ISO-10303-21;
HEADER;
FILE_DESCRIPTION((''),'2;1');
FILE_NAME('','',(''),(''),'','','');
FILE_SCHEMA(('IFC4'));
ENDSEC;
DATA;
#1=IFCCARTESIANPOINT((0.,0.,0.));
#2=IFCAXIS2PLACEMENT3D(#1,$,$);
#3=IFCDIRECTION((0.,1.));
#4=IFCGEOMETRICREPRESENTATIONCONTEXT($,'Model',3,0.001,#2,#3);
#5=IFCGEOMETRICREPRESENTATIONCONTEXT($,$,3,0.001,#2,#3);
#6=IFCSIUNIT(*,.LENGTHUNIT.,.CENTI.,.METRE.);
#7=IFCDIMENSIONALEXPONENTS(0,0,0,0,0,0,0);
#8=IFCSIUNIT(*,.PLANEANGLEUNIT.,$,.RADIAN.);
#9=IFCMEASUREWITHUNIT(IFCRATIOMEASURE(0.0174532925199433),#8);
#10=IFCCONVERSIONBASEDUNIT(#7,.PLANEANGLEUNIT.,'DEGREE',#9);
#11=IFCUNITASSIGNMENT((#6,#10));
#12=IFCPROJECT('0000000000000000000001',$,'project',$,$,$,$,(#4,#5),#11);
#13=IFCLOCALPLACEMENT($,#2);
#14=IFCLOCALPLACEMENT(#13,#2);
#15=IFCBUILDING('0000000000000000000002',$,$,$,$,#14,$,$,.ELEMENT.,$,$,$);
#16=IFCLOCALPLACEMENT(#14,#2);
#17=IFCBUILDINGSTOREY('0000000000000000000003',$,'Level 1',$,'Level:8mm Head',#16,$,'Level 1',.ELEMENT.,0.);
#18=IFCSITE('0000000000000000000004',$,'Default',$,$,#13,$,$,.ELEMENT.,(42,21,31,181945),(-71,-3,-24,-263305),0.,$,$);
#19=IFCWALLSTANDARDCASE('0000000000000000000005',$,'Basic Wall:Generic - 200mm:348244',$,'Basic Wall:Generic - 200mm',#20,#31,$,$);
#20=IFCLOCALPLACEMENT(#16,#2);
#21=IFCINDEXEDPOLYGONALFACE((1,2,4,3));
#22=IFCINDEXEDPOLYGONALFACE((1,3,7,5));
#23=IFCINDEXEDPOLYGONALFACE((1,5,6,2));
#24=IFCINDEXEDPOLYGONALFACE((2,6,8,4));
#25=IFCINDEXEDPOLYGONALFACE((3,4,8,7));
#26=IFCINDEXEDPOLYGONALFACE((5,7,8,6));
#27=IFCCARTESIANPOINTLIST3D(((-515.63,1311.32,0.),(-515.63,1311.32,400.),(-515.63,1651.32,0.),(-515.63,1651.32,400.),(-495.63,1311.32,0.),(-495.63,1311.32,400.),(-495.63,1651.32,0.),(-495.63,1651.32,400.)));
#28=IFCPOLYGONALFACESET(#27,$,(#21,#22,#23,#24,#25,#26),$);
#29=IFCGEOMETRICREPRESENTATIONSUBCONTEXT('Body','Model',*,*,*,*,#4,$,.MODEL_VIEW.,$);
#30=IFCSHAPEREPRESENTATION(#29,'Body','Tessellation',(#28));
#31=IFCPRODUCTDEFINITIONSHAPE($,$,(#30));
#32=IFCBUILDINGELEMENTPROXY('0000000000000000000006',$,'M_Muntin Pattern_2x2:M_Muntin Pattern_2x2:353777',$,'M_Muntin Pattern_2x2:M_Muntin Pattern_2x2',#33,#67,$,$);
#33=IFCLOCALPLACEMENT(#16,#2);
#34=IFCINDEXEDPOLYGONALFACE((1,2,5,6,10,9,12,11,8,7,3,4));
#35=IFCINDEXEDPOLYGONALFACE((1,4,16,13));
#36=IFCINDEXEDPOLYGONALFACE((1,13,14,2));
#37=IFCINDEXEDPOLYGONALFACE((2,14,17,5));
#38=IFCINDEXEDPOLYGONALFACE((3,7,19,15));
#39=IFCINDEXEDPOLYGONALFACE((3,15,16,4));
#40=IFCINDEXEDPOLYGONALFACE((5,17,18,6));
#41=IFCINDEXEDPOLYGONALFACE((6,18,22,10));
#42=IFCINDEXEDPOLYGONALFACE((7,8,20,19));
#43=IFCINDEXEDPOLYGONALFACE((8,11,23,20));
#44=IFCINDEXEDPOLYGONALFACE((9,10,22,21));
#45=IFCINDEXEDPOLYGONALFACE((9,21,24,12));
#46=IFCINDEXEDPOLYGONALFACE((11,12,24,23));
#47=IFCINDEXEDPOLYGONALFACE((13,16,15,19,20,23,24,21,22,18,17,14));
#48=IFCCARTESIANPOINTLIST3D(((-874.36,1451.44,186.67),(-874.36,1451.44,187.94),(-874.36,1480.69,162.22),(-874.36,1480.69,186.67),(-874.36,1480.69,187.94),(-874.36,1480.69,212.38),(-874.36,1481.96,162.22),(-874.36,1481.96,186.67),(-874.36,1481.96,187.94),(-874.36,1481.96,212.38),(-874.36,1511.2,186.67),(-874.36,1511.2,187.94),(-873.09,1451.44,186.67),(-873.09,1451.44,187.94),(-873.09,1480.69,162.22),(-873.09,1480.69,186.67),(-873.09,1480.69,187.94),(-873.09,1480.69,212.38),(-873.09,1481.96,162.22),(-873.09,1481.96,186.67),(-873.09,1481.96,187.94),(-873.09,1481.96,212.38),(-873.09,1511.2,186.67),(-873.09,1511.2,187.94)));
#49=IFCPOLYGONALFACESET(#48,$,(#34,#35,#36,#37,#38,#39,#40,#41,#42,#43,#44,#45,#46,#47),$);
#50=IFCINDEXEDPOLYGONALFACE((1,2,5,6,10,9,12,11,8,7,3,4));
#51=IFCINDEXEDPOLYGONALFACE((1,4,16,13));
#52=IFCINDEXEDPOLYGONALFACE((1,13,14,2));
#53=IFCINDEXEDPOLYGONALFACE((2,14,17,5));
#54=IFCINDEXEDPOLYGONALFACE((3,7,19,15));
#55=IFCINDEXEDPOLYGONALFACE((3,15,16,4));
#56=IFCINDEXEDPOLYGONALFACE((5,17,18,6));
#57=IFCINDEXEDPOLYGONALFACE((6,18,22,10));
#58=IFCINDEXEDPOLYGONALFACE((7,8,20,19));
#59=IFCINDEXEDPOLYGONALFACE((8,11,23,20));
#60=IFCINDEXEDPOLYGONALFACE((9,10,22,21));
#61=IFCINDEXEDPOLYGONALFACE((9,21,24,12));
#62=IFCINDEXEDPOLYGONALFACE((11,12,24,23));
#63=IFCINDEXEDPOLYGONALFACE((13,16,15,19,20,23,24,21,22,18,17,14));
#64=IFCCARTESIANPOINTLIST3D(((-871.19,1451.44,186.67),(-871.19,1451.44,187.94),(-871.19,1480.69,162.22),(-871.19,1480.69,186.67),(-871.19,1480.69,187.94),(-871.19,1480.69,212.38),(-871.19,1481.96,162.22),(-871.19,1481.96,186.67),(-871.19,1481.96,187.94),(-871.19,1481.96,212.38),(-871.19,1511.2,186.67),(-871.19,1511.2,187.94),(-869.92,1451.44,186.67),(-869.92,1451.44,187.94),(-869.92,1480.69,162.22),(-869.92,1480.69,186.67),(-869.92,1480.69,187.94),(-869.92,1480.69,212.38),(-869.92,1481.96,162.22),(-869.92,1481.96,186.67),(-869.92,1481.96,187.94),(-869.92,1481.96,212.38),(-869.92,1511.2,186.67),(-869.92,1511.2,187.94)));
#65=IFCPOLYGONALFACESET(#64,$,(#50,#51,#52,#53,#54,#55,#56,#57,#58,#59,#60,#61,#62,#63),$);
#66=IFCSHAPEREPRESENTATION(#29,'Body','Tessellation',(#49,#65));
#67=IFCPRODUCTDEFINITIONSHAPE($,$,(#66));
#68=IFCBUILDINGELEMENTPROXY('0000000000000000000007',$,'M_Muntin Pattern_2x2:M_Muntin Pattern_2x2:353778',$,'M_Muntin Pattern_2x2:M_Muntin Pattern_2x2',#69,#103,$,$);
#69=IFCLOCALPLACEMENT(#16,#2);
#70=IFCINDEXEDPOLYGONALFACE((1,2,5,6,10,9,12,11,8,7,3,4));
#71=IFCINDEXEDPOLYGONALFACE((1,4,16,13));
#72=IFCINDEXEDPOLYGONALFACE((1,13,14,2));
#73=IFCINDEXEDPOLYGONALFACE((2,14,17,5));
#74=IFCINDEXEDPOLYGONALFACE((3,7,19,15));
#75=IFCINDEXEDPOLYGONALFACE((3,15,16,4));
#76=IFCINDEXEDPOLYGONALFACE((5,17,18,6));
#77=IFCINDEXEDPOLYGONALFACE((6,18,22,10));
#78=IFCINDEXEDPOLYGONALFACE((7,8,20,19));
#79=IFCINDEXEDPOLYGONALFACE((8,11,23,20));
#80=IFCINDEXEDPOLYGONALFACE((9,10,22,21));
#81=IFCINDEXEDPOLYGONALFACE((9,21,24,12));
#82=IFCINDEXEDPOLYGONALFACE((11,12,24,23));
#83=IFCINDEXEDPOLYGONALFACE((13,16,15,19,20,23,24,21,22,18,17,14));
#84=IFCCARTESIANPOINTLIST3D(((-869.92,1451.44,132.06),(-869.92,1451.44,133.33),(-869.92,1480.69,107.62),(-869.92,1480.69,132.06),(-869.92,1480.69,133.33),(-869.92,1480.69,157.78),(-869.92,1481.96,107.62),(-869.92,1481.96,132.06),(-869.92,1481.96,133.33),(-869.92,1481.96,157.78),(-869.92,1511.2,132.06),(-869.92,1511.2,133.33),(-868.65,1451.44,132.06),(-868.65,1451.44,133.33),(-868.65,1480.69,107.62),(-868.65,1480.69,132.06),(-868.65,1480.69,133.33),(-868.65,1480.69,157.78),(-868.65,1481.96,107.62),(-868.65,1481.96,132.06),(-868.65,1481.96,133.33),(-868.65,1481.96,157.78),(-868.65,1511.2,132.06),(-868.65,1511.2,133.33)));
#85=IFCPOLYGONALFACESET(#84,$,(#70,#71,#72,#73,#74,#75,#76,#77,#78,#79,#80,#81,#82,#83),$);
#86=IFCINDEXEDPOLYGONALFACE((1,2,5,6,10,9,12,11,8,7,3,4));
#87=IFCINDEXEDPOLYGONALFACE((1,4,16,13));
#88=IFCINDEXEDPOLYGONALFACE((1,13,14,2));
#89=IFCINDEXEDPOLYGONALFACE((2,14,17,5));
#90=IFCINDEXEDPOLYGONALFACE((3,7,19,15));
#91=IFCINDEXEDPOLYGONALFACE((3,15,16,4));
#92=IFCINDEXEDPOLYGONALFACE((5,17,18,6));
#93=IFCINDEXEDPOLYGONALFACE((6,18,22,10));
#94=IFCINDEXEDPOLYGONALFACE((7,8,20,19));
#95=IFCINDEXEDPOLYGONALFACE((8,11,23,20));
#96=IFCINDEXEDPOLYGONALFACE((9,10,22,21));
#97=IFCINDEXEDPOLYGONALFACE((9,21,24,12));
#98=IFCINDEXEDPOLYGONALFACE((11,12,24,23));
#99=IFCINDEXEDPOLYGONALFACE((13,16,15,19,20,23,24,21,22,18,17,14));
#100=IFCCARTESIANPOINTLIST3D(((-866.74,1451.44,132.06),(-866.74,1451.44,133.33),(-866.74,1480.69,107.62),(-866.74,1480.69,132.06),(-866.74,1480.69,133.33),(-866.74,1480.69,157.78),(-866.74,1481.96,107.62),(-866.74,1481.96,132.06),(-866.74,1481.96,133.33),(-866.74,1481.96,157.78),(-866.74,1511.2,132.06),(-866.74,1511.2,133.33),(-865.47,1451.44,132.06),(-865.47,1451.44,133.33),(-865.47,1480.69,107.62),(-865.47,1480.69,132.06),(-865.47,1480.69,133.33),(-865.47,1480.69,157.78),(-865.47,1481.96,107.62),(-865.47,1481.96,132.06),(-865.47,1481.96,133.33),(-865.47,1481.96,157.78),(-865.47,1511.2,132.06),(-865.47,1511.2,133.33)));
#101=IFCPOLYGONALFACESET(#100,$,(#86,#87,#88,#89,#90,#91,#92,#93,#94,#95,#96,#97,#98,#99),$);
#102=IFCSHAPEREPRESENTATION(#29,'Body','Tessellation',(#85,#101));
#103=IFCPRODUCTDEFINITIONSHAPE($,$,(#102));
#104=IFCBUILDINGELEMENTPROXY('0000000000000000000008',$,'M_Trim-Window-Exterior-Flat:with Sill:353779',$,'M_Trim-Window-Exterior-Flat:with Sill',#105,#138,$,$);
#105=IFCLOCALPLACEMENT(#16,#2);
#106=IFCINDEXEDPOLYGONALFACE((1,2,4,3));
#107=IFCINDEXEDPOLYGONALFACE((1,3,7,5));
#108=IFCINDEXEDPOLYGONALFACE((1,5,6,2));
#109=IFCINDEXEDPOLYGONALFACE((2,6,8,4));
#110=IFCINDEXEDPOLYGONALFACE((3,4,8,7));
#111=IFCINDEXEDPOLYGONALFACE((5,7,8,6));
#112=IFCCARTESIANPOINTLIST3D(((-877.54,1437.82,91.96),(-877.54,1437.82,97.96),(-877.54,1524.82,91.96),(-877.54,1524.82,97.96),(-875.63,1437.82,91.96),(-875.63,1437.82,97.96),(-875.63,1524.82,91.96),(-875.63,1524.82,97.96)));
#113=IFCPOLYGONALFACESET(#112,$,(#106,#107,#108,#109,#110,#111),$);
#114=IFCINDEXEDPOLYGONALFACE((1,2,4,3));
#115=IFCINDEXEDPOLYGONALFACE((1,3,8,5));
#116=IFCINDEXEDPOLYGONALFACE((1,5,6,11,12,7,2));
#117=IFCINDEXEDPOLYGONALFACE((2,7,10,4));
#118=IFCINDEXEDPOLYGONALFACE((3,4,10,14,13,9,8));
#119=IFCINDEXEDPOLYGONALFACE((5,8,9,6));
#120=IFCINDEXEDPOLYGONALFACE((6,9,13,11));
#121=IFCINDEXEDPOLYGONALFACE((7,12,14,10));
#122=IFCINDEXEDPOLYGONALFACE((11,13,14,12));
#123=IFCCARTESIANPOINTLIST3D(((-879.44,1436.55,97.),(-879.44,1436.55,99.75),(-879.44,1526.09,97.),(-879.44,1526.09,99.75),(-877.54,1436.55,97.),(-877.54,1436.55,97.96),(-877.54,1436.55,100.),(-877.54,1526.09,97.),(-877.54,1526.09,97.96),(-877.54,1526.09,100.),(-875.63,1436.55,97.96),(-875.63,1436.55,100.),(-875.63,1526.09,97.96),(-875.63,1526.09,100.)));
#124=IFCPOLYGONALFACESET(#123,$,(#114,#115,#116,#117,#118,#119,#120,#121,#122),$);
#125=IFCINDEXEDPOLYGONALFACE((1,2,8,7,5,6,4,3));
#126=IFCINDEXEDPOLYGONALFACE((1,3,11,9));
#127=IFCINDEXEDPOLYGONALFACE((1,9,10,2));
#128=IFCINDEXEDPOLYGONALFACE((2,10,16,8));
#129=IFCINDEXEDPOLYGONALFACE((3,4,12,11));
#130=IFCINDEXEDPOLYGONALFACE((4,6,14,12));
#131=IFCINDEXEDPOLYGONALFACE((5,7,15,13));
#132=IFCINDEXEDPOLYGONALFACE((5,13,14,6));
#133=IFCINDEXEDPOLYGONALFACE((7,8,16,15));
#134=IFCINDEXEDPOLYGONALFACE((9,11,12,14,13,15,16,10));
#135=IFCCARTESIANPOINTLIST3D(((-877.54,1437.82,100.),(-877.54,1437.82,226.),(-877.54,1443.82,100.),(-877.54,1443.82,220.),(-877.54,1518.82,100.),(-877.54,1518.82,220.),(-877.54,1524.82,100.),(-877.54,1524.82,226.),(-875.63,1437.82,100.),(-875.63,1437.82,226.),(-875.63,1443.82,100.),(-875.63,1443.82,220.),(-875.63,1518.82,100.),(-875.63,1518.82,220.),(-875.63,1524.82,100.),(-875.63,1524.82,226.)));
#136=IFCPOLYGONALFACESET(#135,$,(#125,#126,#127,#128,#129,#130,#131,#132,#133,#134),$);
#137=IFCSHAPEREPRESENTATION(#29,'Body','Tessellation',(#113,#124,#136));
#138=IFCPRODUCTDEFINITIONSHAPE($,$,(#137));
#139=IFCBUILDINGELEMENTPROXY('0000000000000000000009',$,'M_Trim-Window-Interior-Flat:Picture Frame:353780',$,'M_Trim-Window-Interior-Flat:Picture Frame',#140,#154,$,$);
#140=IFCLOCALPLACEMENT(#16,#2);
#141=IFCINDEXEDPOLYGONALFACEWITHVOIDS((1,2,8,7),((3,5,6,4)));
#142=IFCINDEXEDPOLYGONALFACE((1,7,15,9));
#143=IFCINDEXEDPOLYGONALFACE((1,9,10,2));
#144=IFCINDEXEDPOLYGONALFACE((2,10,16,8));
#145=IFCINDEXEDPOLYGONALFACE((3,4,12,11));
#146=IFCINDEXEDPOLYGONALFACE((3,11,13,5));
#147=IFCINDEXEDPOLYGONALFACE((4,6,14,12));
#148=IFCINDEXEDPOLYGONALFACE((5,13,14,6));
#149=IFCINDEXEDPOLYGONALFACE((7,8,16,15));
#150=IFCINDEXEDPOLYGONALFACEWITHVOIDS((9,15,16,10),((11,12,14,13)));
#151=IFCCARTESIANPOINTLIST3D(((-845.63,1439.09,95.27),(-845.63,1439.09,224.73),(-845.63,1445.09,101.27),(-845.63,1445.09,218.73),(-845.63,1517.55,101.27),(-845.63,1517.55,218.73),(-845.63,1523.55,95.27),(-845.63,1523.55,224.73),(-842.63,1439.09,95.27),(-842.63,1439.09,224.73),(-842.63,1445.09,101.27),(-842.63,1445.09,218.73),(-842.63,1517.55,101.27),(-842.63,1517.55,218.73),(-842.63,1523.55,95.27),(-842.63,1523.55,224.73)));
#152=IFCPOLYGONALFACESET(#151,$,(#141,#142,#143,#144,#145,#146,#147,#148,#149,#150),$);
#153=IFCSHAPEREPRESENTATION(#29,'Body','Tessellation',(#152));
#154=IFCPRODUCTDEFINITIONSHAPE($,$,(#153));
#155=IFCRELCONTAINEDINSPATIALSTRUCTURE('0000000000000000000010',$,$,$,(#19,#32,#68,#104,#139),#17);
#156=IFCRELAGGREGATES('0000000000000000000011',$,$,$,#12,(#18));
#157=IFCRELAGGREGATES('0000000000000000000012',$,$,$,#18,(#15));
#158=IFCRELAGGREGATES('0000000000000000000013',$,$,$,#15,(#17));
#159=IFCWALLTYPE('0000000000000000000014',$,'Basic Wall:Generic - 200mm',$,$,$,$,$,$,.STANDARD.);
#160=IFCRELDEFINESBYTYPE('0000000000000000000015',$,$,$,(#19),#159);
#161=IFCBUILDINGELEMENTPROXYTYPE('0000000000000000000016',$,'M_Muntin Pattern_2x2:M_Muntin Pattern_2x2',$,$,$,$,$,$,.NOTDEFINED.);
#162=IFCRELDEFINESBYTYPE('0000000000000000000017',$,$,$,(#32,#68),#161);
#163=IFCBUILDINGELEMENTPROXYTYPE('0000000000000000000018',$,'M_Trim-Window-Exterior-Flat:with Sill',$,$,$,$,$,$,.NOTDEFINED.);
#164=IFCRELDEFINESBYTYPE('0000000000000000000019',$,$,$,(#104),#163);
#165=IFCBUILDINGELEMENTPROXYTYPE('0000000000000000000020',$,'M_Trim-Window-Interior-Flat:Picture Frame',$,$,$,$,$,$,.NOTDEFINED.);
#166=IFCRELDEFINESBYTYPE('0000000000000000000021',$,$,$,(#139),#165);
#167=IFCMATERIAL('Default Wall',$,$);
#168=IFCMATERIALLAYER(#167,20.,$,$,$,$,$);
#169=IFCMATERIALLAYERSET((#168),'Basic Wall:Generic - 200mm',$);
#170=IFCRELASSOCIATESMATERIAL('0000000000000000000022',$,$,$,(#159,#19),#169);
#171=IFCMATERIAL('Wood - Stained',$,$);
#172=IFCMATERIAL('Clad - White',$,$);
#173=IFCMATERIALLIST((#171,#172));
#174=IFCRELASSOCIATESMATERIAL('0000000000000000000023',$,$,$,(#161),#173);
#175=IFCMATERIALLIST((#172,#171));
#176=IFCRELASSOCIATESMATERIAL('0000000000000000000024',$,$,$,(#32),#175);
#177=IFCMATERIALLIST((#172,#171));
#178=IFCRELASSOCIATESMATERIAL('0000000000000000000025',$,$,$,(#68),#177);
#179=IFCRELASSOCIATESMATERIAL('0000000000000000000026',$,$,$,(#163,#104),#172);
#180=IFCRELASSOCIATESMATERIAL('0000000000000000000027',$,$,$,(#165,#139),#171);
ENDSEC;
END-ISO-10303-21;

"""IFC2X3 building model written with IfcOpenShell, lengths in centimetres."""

from ifc_helpers import new_model, entity, si_unit, converted_unit, direction, frame, frame_2d, origin, place, context, subcontext, project, spatial, polyline, rectangle, outline, extrude, source, transform, mapped, material, material_list, layer, layer_set, layer_usage, type_object, type_shapes, element, save


model = new_model("IFC2X3")

# Units and contexts
model_context = context("Model", 3, precision=0.001, world=origin(), true_north=direction((0.0, 1.0)))
context_of_model = context(None, 3, precision=0.001, world=origin(), true_north=direction((0.0, 1.0)))
body_context = subcontext(model_context, "Body", "Model", "MODEL_VIEW")
ifc_project = project(units=[si_unit("LENGTHUNIT", "METRE", prefix="CENTI"), converted_unit("PLANEANGLEUNIT", "DEGREE", entity("IfcRatioMeasure", 0.0174532925199433), si_unit("PLANEANGLEUNIT", "RADIAN"), dimensions=[0, 0, 0, 0, 0, 0, 0])], contexts=[model_context, context_of_model])

# Site, building, storey
site_placement = place(None, origin())
site = spatial("IfcSite", under=ifc_project, at=site_placement, Name="Default", CompositionType="ELEMENT", RefLatitude=(42, 21, 31, 181945), RefLongitude=(-71, -3, -24, -263305), RefElevation=0.0)
building_placement = place(site_placement, origin())
building = spatial("IfcBuilding", under=site, at=building_placement, CompositionType="ELEMENT")
storey_placement = place(building_placement, origin())
storey = spatial("IfcBuildingStorey", under=building, at=storey_placement, Name="Level 1", ObjectType="Level:8mm Head", LongName="Level 1", CompositionType="ELEMENT", Elevation=0.0)

# Shared definitions
ifc_material_1 = material(Name="Default Wall")

# Shared definitions
ifc_layer_1 = layer(ifc_material_1, 20.0)
ifc_layer_set_1 = layer_set([ifc_layer_1], Name="Basic Wall:Generic - 200mm")
wall_type_1 = type_object("IfcWallType", Name="Basic Wall:Generic - 200mm", PredefinedType="STANDARD", material=ifc_layer_set_1)

# Wall
ifc_layer_usage_1 = layer_usage(ifc_layer_set_1, "AXIS2", "NEGATIVE", 10.0)
wall_1_placement = place(storey_placement, frame((-505.63, 1311.32, 0.0), z_axis=(0.0, 0.0, 1.0), x_axis=(0.0, 1.0, 0.0)))
element("IfcWallStandardCase", 1, at=wall_1_placement, inside=storey, type_object=wall_type_1, material=ifc_layer_usage_1, Name="Basic Wall:Generic - 200mm:348244", ObjectType="Basic Wall:Generic - 200mm", context=body_context, shape_type="SweptSolid", body=[
    extrude(rectangle(XDim=340.0, YDim=20.0, at=frame_2d((170.0, 0.0), x_axis=(-1.0, 0.0))), origin(), (0.0, 0.0, 1.0), 400.0),
])

# Building element proxies
ifc_material_2 = material(Name="Clad - White")
ifc_material_3 = material(Name="Wood - Stained")
ifc_material_list_1 = material_list([ifc_material_2, ifc_material_3])
ifc_material_list_2 = material_list([ifc_material_3, ifc_material_2])
building_element_proxy_type_1 = type_object("IfcBuildingElementProxyType", Name="M_Muntin Pattern_2x2:M_Muntin Pattern_2x2", PredefinedType="NOTDEFINED", material=ifc_material_list_2)
shared_shape_1 = source(origin(), body_context, "Body", "SweptSolid", [
    extrude(outline(polyline([(0.64, -0.64), (25.08, -0.64), (25.08, 0.63), (0.64, 0.63), (0.64, 29.88), (-0.63, 29.88), (-0.63, 0.63), (-25.08, 0.63), (-25.08, -0.64), (-0.63, -0.64), (-0.63, -29.88), (0.64, -29.88), (0.64, -0.64)])), frame((0.0, 0.95, 25.08), z_axis=(0.0, 1.0, 0.0), x_axis=(0.0, 0.0, 1.0)), (0.0, 0.0, 1.0), 1.27),
    extrude(outline(polyline([(0.64, -0.64), (25.08, -0.64), (25.08, 0.63), (0.64, 0.63), (0.64, 29.88), (-0.63, 29.88), (-0.63, 0.63), (-25.08, 0.63), (-25.08, -0.64), (-0.63, -0.64), (-0.63, -29.88), (0.64, -29.88), (0.64, -0.64)])), frame((0.0, -2.22, 25.08), z_axis=(0.0, 1.0, 0.0), x_axis=(0.0, 0.0, 1.0)), (0.0, 0.0, 1.0), 1.27),
])
type_shapes(building_element_proxy_type_1, [shared_shape_1])
proxy_1_placement = place(storey_placement, frame((-872.14, 1481.32, 162.22), z_axis=(0.0, 0.0, 1.0), x_axis=(0.0, 1.0, 0.0)))
element("IfcBuildingElementProxy", 2, at=proxy_1_placement, inside=storey, type_object=building_element_proxy_type_1, material=ifc_material_list_1, Name="M_Muntin Pattern_2x2:M_Muntin Pattern_2x2:353777", ObjectType="M_Muntin Pattern_2x2:M_Muntin Pattern_2x2", context=body_context, shape_type="MappedRepresentation", body=[
    mapped(shared_shape_1, transform((0.0, 0.0, 0.0), scale=1.0)),
])
ifc_material_list_3 = material_list([ifc_material_2, ifc_material_3])
proxy_2_placement = place(storey_placement, frame((-867.7, 1481.32, 107.62), z_axis=(0.0, 0.0, 1.0), x_axis=(0.0, 1.0, 0.0)))
element("IfcBuildingElementProxy", 3, at=proxy_2_placement, inside=storey, type_object=building_element_proxy_type_1, material=ifc_material_list_3, Name="M_Muntin Pattern_2x2:M_Muntin Pattern_2x2:353778", ObjectType="M_Muntin Pattern_2x2:M_Muntin Pattern_2x2", context=body_context, shape_type="MappedRepresentation", body=[
    mapped(shared_shape_1, transform((0.0, 0.0, 0.0), scale=1.0)),
])
building_element_proxy_type_2 = type_object("IfcBuildingElementProxyType", Name="M_Trim-Window-Exterior-Flat:with Sill", PredefinedType="NOTDEFINED", material=ifc_material_2)
shared_shape_2 = source(origin(), body_context, "Body", "SweptSolid", [
    extrude(rectangle(XDim=87.0, YDim=6.0, at=frame_2d((0.0, 0.0), x_axis=(1.0, 0.0))), frame((0.0, -125.04, 0.0), z_axis=(0.0, 0.0, 1.0), x_axis=(-1.0, 0.0, 0.0)), (0.0, 0.0, 1.0), 1.91),
    extrude(outline(polyline([(-1.9, -1.52), (0.0, -1.52), (0.0, -0.57), (1.9, -0.57), (1.9, 1.48), (0.0, 1.48), (-1.9, 1.23), (-1.9, -1.52)])), frame((-44.77, -121.48, 1.9), z_axis=(1.0, 0.0, 0.0), x_axis=(0.0, 0.0, -1.0)), (0.0, 0.0, 1.0), 89.54),
    extrude(outline(polyline([(-64.5, -43.5), (61.5, -43.5), (61.5, -37.5), (-58.5, -37.5), (-58.5, 37.5), (61.5, 37.5), (61.5, 43.5), (-64.5, 43.5), (-64.5, -43.5)])), frame((0.0, -58.5, 0.0), z_axis=(0.0, 0.0, 1.0), x_axis=(0.0, -1.0, 0.0)), (0.0, 0.0, 1.0), 1.91),
])
type_shapes(building_element_proxy_type_2, [shared_shape_2])
proxy_3_placement = place(storey_placement, frame((-875.63, 1481.32, 220.0), z_axis=(-1.0, 0.0, 0.0), x_axis=(0.0, -1.0, 0.0)))
element("IfcBuildingElementProxy", 4, at=proxy_3_placement, inside=storey, type_object=building_element_proxy_type_2, material=ifc_material_2, Name="M_Trim-Window-Exterior-Flat:with Sill:353779", ObjectType="M_Trim-Window-Exterior-Flat:with Sill", context=body_context, shape_type="MappedRepresentation", body=[
    mapped(shared_shape_2, transform((0.0, 0.0, 0.0), scale=1.0)),
])
building_element_proxy_type_3 = type_object("IfcBuildingElementProxyType", Name="M_Trim-Window-Interior-Flat:Picture Frame", PredefinedType="NOTDEFINED", material=ifc_material_3)
shared_shape_3 = source(origin(), body_context, "Body", "SweptSolid", [
    extrude(outline(polyline([(-42.23, -64.73), (42.23, -64.73), (42.23, 64.73), (-42.23, 64.73), (-42.23, -64.73)]), holes=[polyline([(-36.23, -58.73), (-36.23, 58.73), (36.23, 58.73), (36.23, -58.73), (-36.23, -58.73)])]), frame((0.0, -60.0, 0.0), z_axis=(0.0, 0.0, 1.0), x_axis=(-1.0, 0.0, 0.0)), (0.0, 0.0, 1.0), 3.0),
])
type_shapes(building_element_proxy_type_3, [shared_shape_3])
proxy_4_placement = place(storey_placement, frame((-845.63, 1481.32, 220.0), z_axis=(1.0, 0.0, 0.0), x_axis=(0.0, 1.0, 0.0)))
element("IfcBuildingElementProxy", 5, at=proxy_4_placement, inside=storey, type_object=building_element_proxy_type_3, material=ifc_material_3, Name="M_Trim-Window-Interior-Flat:Picture Frame:353780", ObjectType="M_Trim-Window-Interior-Flat:Picture Frame", context=body_context, shape_type="MappedRepresentation", body=[
    mapped(shared_shape_3, transform((0.0, 0.0, 0.0), scale=1.0)),
])

save(model, "model.ifc")
